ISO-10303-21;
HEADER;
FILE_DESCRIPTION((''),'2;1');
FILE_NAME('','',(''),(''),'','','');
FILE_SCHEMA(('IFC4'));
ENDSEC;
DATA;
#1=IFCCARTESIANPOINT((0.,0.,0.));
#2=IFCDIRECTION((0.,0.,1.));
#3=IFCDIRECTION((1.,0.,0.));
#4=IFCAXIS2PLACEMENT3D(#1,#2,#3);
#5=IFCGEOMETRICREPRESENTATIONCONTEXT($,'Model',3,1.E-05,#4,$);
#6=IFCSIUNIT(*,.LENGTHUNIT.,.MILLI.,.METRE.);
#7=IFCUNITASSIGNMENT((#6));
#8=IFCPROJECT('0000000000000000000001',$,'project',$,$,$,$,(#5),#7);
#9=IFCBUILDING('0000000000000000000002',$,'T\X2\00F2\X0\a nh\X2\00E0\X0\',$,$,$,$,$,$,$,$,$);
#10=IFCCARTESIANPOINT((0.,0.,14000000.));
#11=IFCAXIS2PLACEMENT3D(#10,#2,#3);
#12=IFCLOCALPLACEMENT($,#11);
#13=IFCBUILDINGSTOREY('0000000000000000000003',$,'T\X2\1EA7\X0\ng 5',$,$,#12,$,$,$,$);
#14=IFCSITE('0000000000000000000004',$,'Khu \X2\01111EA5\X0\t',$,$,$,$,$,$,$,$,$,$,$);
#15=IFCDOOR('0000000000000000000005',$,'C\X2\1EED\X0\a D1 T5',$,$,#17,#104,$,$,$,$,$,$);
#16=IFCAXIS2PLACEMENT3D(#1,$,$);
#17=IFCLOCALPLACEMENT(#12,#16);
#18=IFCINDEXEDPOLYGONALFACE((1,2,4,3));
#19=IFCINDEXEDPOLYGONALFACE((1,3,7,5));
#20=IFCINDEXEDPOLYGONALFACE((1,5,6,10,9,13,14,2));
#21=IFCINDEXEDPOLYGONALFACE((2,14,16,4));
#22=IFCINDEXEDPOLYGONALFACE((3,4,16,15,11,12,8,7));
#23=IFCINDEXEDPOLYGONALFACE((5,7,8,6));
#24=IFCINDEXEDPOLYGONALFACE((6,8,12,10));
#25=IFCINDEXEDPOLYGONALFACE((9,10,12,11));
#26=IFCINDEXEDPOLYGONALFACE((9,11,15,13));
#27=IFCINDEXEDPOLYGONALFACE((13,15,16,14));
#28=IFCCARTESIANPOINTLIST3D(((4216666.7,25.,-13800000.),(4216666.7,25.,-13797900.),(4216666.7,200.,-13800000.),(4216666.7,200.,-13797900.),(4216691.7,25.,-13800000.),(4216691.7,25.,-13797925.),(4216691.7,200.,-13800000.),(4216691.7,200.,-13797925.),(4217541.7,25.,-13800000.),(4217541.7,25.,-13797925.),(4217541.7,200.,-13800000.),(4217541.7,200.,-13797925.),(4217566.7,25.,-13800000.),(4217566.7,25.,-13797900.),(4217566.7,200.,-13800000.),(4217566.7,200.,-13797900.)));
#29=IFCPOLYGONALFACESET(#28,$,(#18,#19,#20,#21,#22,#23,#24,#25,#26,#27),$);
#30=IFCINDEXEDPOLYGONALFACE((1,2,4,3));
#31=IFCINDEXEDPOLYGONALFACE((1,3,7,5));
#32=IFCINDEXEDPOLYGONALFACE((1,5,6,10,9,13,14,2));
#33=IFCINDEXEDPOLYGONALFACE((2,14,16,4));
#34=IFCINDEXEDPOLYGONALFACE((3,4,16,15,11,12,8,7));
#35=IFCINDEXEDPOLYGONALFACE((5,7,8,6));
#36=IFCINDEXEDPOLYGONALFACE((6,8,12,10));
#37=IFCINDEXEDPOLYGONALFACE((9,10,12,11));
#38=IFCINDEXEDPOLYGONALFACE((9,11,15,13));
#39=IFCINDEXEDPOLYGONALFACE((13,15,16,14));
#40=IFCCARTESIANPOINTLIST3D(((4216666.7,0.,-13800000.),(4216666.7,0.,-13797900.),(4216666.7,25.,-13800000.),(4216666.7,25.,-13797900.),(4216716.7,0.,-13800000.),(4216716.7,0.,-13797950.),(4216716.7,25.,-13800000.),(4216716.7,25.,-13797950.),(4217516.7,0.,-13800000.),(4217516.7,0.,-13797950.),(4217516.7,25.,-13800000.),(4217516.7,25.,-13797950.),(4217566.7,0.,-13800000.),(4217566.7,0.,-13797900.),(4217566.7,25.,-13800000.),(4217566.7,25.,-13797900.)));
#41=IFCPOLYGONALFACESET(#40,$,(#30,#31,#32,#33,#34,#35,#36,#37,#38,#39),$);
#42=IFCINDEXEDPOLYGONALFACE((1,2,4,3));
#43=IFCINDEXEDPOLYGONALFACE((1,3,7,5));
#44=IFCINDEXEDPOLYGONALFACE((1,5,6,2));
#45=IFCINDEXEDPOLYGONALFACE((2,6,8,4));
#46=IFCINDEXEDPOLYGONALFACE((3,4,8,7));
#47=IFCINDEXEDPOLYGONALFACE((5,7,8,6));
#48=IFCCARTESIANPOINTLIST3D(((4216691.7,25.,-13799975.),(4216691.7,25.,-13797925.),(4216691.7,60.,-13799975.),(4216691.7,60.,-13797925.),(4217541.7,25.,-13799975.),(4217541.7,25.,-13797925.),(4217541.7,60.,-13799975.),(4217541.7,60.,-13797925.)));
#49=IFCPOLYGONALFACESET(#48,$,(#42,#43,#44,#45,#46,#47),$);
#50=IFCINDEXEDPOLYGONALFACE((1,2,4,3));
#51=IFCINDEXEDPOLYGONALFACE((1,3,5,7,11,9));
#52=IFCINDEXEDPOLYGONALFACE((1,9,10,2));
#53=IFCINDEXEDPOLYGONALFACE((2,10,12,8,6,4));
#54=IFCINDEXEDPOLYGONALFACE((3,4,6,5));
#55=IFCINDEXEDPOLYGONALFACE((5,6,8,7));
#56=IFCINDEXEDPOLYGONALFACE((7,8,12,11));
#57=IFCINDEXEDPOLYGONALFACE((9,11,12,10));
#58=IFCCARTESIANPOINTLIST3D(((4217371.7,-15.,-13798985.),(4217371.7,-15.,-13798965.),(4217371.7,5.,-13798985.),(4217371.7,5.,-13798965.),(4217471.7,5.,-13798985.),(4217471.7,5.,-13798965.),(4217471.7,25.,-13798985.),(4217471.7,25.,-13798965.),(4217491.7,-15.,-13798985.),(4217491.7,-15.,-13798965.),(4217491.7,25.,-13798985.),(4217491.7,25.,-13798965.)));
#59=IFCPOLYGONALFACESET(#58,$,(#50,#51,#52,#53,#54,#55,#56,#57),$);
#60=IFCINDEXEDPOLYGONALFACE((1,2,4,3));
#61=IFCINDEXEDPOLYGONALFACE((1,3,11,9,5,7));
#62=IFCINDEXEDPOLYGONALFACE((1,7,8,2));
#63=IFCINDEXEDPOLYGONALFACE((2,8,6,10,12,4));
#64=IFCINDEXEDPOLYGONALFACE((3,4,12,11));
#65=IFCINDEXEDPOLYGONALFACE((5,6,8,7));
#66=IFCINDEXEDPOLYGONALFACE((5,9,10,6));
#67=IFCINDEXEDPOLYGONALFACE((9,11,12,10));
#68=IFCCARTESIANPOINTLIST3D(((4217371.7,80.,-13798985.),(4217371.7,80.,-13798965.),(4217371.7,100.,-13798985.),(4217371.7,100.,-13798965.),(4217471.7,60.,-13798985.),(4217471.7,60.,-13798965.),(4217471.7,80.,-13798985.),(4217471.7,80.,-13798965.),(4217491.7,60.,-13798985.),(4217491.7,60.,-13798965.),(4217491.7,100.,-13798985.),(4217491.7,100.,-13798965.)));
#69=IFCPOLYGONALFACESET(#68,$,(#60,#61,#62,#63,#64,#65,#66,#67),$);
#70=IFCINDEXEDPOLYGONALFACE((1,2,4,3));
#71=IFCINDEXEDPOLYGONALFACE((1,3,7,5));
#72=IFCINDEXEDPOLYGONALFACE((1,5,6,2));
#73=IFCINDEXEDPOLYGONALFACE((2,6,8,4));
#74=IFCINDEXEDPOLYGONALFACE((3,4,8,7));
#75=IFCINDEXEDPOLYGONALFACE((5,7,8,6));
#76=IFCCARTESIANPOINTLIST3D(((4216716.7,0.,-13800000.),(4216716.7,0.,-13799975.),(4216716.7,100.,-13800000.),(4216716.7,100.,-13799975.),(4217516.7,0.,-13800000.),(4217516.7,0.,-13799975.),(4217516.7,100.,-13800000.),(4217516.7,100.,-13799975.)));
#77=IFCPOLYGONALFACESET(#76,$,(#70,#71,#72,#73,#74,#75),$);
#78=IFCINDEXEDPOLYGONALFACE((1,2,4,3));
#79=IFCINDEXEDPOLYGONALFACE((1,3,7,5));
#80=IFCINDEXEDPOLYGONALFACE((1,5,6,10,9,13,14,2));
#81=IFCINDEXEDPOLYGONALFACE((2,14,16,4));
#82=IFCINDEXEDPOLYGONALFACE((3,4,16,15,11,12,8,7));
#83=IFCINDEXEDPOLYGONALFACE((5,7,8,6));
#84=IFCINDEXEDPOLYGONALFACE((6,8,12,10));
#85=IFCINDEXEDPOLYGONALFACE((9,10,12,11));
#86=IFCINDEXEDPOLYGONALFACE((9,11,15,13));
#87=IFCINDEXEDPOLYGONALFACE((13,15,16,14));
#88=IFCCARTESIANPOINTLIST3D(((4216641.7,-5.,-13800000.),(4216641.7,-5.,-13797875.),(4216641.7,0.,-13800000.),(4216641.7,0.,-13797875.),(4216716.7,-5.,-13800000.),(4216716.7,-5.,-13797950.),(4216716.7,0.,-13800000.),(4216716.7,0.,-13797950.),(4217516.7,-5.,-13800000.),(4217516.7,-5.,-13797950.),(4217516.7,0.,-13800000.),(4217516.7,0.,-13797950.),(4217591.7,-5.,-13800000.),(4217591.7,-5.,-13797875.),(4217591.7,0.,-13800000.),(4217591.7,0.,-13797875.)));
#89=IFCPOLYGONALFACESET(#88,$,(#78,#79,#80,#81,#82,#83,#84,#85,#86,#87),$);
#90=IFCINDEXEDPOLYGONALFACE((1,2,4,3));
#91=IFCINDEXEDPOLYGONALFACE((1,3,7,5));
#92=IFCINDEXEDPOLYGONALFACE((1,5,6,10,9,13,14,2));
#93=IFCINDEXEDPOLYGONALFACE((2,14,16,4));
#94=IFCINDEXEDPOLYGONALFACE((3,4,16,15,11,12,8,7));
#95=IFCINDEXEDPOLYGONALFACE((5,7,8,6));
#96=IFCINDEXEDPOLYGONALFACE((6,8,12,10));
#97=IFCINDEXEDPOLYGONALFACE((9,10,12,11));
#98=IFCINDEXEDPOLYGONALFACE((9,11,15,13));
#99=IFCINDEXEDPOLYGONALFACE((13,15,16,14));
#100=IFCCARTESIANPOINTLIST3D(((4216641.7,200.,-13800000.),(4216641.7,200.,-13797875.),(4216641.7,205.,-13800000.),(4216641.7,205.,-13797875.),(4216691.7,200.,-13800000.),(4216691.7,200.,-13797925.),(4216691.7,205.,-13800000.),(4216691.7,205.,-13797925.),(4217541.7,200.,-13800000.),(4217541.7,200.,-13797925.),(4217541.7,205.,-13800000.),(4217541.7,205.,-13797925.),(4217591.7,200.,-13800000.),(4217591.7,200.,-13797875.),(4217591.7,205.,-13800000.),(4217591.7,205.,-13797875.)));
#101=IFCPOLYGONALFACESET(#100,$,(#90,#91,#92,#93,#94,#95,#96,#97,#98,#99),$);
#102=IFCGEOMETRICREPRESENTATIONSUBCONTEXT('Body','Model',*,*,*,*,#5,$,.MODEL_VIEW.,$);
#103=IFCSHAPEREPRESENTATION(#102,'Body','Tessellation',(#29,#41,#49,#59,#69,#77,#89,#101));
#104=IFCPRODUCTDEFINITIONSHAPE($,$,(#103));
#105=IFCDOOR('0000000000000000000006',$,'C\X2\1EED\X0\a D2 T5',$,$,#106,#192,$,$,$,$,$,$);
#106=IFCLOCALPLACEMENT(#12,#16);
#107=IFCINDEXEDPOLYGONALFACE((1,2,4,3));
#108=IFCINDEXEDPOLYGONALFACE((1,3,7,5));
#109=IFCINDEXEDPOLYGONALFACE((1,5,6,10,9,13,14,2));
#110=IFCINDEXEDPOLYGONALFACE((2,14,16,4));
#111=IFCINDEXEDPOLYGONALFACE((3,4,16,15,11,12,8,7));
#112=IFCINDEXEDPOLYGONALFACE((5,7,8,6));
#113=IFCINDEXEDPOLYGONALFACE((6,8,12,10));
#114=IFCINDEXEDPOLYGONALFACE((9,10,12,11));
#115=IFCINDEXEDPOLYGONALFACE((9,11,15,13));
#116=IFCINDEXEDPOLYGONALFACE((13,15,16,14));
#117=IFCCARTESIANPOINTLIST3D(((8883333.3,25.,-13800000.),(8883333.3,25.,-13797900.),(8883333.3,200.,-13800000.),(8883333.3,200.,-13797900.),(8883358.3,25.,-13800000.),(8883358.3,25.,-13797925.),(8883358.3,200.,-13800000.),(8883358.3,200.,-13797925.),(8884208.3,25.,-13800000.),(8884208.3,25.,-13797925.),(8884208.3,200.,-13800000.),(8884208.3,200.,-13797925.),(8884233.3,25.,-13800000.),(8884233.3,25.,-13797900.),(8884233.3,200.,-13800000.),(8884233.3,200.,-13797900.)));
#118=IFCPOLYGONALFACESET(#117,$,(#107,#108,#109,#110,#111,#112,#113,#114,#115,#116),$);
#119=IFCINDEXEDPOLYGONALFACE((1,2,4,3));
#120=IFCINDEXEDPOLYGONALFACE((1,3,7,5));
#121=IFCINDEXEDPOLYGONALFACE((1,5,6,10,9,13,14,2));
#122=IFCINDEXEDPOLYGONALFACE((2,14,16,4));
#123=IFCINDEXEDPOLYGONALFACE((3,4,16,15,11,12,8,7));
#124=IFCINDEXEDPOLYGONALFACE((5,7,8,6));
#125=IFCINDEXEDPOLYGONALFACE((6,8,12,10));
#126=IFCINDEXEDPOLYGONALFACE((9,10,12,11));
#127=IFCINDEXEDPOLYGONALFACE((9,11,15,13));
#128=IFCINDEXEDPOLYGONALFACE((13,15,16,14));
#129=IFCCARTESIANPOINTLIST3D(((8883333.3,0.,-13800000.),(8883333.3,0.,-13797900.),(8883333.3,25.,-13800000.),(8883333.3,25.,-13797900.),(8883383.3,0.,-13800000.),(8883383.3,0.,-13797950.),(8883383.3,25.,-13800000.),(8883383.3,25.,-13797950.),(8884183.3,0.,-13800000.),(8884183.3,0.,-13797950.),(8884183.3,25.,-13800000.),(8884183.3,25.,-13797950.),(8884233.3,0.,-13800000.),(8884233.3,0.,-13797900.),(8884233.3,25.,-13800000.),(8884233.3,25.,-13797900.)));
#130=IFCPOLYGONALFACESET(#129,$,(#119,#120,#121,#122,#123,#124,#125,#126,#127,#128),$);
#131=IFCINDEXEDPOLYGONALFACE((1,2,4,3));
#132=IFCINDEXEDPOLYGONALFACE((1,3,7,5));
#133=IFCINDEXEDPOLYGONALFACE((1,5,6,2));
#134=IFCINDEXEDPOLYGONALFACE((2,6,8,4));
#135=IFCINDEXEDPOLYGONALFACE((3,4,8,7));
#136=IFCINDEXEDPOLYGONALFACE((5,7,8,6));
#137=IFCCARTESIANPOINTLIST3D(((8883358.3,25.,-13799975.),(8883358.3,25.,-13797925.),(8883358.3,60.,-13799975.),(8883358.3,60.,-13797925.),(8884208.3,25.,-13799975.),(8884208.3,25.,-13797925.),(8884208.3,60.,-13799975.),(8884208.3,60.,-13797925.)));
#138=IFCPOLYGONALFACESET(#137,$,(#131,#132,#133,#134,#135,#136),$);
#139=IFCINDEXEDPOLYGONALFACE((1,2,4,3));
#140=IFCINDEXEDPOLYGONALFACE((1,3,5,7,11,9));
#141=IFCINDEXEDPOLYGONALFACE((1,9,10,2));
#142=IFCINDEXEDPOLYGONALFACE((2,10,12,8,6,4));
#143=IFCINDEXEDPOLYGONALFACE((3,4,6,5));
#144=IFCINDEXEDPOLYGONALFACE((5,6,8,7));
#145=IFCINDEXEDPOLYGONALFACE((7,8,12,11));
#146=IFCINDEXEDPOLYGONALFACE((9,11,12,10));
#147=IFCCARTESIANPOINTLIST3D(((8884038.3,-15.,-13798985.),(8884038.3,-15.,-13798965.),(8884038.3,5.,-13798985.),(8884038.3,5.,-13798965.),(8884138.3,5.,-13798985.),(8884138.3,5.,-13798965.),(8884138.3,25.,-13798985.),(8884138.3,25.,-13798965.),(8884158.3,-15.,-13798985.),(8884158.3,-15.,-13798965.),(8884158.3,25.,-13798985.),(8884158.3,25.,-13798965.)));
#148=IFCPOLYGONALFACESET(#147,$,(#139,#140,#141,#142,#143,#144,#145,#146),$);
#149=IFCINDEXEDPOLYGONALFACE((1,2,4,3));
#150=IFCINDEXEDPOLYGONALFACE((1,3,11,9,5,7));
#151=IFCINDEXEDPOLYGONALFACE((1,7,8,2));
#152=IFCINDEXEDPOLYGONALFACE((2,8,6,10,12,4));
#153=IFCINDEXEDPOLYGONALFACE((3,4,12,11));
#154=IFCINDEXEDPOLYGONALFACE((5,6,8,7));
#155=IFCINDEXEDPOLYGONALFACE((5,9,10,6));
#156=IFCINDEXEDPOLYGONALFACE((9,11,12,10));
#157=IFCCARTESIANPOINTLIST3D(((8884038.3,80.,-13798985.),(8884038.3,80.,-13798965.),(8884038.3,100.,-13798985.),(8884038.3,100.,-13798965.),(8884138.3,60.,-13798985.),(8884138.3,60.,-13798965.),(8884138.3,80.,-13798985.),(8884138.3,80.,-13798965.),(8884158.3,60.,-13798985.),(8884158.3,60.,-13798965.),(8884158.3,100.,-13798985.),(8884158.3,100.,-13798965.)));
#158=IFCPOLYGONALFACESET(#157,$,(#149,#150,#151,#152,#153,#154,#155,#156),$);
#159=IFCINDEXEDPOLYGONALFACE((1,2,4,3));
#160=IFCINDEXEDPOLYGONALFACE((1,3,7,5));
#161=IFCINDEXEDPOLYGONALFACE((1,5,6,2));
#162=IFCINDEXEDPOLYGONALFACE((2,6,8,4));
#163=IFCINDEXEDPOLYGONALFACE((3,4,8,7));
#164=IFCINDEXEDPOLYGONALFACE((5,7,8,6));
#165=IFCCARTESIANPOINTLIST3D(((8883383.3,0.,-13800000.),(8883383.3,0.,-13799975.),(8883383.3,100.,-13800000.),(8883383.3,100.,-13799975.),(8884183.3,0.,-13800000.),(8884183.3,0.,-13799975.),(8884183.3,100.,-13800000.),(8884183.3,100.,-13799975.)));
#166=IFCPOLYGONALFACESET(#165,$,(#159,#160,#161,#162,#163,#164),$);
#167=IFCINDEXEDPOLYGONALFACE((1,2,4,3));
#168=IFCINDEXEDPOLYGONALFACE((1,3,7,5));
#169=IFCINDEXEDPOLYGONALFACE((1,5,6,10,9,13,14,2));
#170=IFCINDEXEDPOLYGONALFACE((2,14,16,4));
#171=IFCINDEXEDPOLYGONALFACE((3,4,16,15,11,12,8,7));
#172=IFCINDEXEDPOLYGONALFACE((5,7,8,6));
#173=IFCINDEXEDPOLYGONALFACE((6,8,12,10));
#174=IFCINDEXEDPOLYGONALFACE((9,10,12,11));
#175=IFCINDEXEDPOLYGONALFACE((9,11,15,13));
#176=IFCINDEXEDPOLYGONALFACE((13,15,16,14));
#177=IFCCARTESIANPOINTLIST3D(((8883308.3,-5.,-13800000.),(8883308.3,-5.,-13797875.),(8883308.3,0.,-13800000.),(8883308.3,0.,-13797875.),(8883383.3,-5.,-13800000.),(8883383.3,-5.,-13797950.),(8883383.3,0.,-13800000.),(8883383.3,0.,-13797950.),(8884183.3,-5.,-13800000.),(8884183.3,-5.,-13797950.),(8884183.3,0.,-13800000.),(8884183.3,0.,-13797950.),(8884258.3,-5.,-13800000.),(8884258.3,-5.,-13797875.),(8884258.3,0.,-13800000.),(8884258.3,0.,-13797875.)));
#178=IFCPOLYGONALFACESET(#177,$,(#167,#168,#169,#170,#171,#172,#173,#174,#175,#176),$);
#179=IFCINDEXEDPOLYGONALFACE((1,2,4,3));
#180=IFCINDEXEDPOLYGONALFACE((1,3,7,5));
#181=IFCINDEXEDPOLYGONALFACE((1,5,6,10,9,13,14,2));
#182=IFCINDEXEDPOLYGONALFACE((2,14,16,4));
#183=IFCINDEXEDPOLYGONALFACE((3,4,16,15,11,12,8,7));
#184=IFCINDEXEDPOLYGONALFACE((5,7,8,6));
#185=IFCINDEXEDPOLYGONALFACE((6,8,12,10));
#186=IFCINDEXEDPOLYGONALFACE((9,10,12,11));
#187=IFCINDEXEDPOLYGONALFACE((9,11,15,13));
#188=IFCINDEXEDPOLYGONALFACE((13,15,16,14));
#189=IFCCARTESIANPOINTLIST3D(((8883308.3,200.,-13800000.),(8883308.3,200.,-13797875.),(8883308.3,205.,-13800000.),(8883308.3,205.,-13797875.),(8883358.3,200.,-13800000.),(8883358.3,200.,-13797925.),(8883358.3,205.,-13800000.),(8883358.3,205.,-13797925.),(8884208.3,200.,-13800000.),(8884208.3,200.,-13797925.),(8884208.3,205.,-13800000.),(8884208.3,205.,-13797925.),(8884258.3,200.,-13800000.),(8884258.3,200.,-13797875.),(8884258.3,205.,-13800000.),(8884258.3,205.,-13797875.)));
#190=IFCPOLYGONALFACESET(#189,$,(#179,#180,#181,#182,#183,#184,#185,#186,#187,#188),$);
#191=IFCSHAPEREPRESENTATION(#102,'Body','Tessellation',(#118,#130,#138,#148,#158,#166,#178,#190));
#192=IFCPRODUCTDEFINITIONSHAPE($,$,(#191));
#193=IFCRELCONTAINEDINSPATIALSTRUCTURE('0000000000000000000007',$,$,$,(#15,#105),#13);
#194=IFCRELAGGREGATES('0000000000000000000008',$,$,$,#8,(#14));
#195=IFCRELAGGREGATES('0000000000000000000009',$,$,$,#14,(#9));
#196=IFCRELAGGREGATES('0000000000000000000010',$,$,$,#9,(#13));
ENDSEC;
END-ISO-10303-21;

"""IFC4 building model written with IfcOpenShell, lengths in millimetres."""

from ifc_helpers import new_model, si_unit, frame, origin_with_axes, place, context, subcontext, project, spatial, line, indexed_curve, outline, extrude, element, save


model = new_model("IFC4")

# Units and contexts
model_context = context("Model", 3, precision=1e-05, world=origin_with_axes())
body_context = subcontext(model_context, "Body", "Model", "MODEL_VIEW")
ifc_project = project(units=[si_unit("LENGTHUNIT", "METRE", prefix="MILLI")], contexts=[model_context])

# Site, building, storey
site = spatial("IfcSite", under=ifc_project, Name="Khu đất")
building = spatial("IfcBuilding", under=site, Name="Tòa nhà")
storey_placement = place(None, frame((0.0, 0.0, 14000000.0), z_axis=(0.0, 0.0, 1.0), x_axis=(1.0, 0.0, 0.0)))
storey = spatial("IfcBuildingStorey", under=building, at=storey_placement, Name="Tầng 5")

# Doors
door_1_placement = place(storey_placement, frame((4216666.7, 0.0, -13800000.0), z_axis=(0.0, 0.0, 1.0), x_axis=(1.0, 0.0, 0.0)))
element("IfcDoor", 1, at=door_1_placement, inside=storey, Name="Cửa D1 T5", context=body_context, shape_type="SolidModel", body=[
    extrude(outline(indexed_curve([(0.0, 0.0), (0.0, 2100.0), (900.0, 2100.0), (900.0, 0.0), (875.0, 0.0), (875.0, 2075.0), (25.0, 2075.0), (25.0, 0.0)], segments=[line(1, 2, 3, 4, 5, 6, 7, 8, 1)])), frame((0.0, 25.0, 0.0), z_axis=(0.0, -1.0, 0.0), x_axis=(1.0, 0.0, 0.0)), (0.0, 0.0, -1.0), 175.0),
    extrude(outline(indexed_curve([(0.0, 0.0), (0.0, 2100.0), (900.0, 2100.0), (900.0, 0.0), (850.0, 0.0), (850.0, 2050.0), (50.0, 2050.0), (50.0, 0.0)], segments=[line(1, 2, 3, 4, 5, 6, 7, 8, 1)])), frame((0.0, 0.0, 0.0), z_axis=(0.0, -1.0, 0.0), x_axis=(1.0, 0.0, 0.0)), (0.0, 0.0, -1.0), 25.0),
    extrude(outline(indexed_curve([(0.0, 0.0), (850.0, 0.0), (850.0, 35.0), (0.0, 35.0)], segments=[line(1, 2, 3, 4, 1)])), frame((25.0, 25.0, 25.0), z_axis=(0.0, 0.0, 1.0), x_axis=(1.0, 0.0, 0.0)), (0.0, 0.0, 1.0), 2050.0),
    extrude(outline(indexed_curve([(0.0, 0.0), (0.0, -40.0), (-120.0, -40.0), (-120.0, -20.0), (-20.0, -20.0), (-20.0, 0.0)], segments=[line(1, 2, 3, 4, 5, 6, 1)])), frame((825.0, 25.0, 1015.0), z_axis=(0.0, 0.0, 1.0), x_axis=(1.0, 0.0, 0.0)), (0.0, 0.0, 1.0), 20.0),
    extrude(outline(indexed_curve([(0.0, 0.0), (0.0, 40.0), (-120.0, 40.0), (-120.0, 20.0), (-20.0, 20.0), (-20.0, 0.0)], segments=[line(1, 2, 3, 4, 5, 6, 1)])), frame((825.0, 60.0, 1015.0), z_axis=(0.0, 0.0, 1.0), x_axis=(1.0, 0.0, 0.0)), (0.0, 0.0, 1.0), 20.0),
    extrude(outline(indexed_curve([(0.0, 0.0), (800.0, 0.0), (800.0, 100.0), (0.0, 100.0)], segments=[line(1, 2, 3, 4, 1)])), frame((50.0, 0.0, 0.0), z_axis=(0.0, 0.0, 1.0), x_axis=(1.0, 0.0, 0.0)), (0.0, 0.0, 1.0), 25.0),
    extrude(outline(indexed_curve([(0.0, 0.0), (0.0, 2125.0), (950.0, 2125.0), (950.0, 0.0), (875.0, 0.0), (875.0, 2050.0), (75.0, 2050.0), (75.0, 0.0)], segments=[line(1, 2, 3, 4, 5, 6, 7, 8, 1)])), frame((-25.0, -5.0, 0.0), z_axis=(0.0, -1.0, 0.0), x_axis=(1.0, 0.0, 0.0)), (0.0, 0.0, -1.0), 5.0),
    extrude(outline(indexed_curve([(0.0, 0.0), (0.0, 2125.0), (950.0, 2125.0), (950.0, 0.0), (900.0, 0.0), (900.0, 2075.0), (50.0, 2075.0), (50.0, 0.0)], segments=[line(1, 2, 3, 4, 5, 6, 7, 8, 1)])), frame((-25.0, 200.0, 0.0), z_axis=(0.0, -1.0, 0.0), x_axis=(1.0, 0.0, 0.0)), (0.0, 0.0, -1.0), 5.0),
])
door_2_placement = place(storey_placement, frame((8883333.3, 0.0, -13800000.0), z_axis=(0.0, 0.0, 1.0), x_axis=(1.0, 0.0, 0.0)))
element("IfcDoor", 2, at=door_2_placement, inside=storey, Name="Cửa D2 T5", context=body_context, shape_type="SolidModel", body=[
    extrude(outline(indexed_curve([(0.0, 0.0), (0.0, 2100.0), (900.0, 2100.0), (900.0, 0.0), (875.0, 0.0), (875.0, 2075.0), (25.0, 2075.0), (25.0, 0.0)], segments=[line(1, 2, 3, 4, 5, 6, 7, 8, 1)])), frame((0.0, 25.0, 0.0), z_axis=(0.0, -1.0, 0.0), x_axis=(1.0, 0.0, 0.0)), (0.0, 0.0, -1.0), 175.0),
    extrude(outline(indexed_curve([(0.0, 0.0), (0.0, 2100.0), (900.0, 2100.0), (900.0, 0.0), (850.0, 0.0), (850.0, 2050.0), (50.0, 2050.0), (50.0, 0.0)], segments=[line(1, 2, 3, 4, 5, 6, 7, 8, 1)])), frame((0.0, 0.0, 0.0), z_axis=(0.0, -1.0, 0.0), x_axis=(1.0, 0.0, 0.0)), (0.0, 0.0, -1.0), 25.0),
    extrude(outline(indexed_curve([(0.0, 0.0), (850.0, 0.0), (850.0, 35.0), (0.0, 35.0)], segments=[line(1, 2, 3, 4, 1)])), frame((25.0, 25.0, 25.0), z_axis=(0.0, 0.0, 1.0), x_axis=(1.0, 0.0, 0.0)), (0.0, 0.0, 1.0), 2050.0),
    extrude(outline(indexed_curve([(0.0, 0.0), (0.0, -40.0), (-120.0, -40.0), (-120.0, -20.0), (-20.0, -20.0), (-20.0, 0.0)], segments=[line(1, 2, 3, 4, 5, 6, 1)])), frame((825.0, 25.0, 1015.0), z_axis=(0.0, 0.0, 1.0), x_axis=(1.0, 0.0, 0.0)), (0.0, 0.0, 1.0), 20.0),
    extrude(outline(indexed_curve([(0.0, 0.0), (0.0, 40.0), (-120.0, 40.0), (-120.0, 20.0), (-20.0, 20.0), (-20.0, 0.0)], segments=[line(1, 2, 3, 4, 5, 6, 1)])), frame((825.0, 60.0, 1015.0), z_axis=(0.0, 0.0, 1.0), x_axis=(1.0, 0.0, 0.0)), (0.0, 0.0, 1.0), 20.0),
    extrude(outline(indexed_curve([(0.0, 0.0), (800.0, 0.0), (800.0, 100.0), (0.0, 100.0)], segments=[line(1, 2, 3, 4, 1)])), frame((50.0, 0.0, 0.0), z_axis=(0.0, 0.0, 1.0), x_axis=(1.0, 0.0, 0.0)), (0.0, 0.0, 1.0), 25.0),
    extrude(outline(indexed_curve([(0.0, 0.0), (0.0, 2125.0), (950.0, 2125.0), (950.0, 0.0), (875.0, 0.0), (875.0, 2050.0), (75.0, 2050.0), (75.0, 0.0)], segments=[line(1, 2, 3, 4, 5, 6, 7, 8, 1)])), frame((-25.0, -5.0, 0.0), z_axis=(0.0, -1.0, 0.0), x_axis=(1.0, 0.0, 0.0)), (0.0, 0.0, -1.0), 5.0),
    extrude(outline(indexed_curve([(0.0, 0.0), (0.0, 2125.0), (950.0, 2125.0), (950.0, 0.0), (900.0, 0.0), (900.0, 2075.0), (50.0, 2075.0), (50.0, 0.0)], segments=[line(1, 2, 3, 4, 5, 6, 7, 8, 1)])), frame((-25.0, 200.0, 0.0), z_axis=(0.0, -1.0, 0.0), x_axis=(1.0, 0.0, 0.0)), (0.0, 0.0, -1.0), 5.0),
])

save(model, "model.ifc")
